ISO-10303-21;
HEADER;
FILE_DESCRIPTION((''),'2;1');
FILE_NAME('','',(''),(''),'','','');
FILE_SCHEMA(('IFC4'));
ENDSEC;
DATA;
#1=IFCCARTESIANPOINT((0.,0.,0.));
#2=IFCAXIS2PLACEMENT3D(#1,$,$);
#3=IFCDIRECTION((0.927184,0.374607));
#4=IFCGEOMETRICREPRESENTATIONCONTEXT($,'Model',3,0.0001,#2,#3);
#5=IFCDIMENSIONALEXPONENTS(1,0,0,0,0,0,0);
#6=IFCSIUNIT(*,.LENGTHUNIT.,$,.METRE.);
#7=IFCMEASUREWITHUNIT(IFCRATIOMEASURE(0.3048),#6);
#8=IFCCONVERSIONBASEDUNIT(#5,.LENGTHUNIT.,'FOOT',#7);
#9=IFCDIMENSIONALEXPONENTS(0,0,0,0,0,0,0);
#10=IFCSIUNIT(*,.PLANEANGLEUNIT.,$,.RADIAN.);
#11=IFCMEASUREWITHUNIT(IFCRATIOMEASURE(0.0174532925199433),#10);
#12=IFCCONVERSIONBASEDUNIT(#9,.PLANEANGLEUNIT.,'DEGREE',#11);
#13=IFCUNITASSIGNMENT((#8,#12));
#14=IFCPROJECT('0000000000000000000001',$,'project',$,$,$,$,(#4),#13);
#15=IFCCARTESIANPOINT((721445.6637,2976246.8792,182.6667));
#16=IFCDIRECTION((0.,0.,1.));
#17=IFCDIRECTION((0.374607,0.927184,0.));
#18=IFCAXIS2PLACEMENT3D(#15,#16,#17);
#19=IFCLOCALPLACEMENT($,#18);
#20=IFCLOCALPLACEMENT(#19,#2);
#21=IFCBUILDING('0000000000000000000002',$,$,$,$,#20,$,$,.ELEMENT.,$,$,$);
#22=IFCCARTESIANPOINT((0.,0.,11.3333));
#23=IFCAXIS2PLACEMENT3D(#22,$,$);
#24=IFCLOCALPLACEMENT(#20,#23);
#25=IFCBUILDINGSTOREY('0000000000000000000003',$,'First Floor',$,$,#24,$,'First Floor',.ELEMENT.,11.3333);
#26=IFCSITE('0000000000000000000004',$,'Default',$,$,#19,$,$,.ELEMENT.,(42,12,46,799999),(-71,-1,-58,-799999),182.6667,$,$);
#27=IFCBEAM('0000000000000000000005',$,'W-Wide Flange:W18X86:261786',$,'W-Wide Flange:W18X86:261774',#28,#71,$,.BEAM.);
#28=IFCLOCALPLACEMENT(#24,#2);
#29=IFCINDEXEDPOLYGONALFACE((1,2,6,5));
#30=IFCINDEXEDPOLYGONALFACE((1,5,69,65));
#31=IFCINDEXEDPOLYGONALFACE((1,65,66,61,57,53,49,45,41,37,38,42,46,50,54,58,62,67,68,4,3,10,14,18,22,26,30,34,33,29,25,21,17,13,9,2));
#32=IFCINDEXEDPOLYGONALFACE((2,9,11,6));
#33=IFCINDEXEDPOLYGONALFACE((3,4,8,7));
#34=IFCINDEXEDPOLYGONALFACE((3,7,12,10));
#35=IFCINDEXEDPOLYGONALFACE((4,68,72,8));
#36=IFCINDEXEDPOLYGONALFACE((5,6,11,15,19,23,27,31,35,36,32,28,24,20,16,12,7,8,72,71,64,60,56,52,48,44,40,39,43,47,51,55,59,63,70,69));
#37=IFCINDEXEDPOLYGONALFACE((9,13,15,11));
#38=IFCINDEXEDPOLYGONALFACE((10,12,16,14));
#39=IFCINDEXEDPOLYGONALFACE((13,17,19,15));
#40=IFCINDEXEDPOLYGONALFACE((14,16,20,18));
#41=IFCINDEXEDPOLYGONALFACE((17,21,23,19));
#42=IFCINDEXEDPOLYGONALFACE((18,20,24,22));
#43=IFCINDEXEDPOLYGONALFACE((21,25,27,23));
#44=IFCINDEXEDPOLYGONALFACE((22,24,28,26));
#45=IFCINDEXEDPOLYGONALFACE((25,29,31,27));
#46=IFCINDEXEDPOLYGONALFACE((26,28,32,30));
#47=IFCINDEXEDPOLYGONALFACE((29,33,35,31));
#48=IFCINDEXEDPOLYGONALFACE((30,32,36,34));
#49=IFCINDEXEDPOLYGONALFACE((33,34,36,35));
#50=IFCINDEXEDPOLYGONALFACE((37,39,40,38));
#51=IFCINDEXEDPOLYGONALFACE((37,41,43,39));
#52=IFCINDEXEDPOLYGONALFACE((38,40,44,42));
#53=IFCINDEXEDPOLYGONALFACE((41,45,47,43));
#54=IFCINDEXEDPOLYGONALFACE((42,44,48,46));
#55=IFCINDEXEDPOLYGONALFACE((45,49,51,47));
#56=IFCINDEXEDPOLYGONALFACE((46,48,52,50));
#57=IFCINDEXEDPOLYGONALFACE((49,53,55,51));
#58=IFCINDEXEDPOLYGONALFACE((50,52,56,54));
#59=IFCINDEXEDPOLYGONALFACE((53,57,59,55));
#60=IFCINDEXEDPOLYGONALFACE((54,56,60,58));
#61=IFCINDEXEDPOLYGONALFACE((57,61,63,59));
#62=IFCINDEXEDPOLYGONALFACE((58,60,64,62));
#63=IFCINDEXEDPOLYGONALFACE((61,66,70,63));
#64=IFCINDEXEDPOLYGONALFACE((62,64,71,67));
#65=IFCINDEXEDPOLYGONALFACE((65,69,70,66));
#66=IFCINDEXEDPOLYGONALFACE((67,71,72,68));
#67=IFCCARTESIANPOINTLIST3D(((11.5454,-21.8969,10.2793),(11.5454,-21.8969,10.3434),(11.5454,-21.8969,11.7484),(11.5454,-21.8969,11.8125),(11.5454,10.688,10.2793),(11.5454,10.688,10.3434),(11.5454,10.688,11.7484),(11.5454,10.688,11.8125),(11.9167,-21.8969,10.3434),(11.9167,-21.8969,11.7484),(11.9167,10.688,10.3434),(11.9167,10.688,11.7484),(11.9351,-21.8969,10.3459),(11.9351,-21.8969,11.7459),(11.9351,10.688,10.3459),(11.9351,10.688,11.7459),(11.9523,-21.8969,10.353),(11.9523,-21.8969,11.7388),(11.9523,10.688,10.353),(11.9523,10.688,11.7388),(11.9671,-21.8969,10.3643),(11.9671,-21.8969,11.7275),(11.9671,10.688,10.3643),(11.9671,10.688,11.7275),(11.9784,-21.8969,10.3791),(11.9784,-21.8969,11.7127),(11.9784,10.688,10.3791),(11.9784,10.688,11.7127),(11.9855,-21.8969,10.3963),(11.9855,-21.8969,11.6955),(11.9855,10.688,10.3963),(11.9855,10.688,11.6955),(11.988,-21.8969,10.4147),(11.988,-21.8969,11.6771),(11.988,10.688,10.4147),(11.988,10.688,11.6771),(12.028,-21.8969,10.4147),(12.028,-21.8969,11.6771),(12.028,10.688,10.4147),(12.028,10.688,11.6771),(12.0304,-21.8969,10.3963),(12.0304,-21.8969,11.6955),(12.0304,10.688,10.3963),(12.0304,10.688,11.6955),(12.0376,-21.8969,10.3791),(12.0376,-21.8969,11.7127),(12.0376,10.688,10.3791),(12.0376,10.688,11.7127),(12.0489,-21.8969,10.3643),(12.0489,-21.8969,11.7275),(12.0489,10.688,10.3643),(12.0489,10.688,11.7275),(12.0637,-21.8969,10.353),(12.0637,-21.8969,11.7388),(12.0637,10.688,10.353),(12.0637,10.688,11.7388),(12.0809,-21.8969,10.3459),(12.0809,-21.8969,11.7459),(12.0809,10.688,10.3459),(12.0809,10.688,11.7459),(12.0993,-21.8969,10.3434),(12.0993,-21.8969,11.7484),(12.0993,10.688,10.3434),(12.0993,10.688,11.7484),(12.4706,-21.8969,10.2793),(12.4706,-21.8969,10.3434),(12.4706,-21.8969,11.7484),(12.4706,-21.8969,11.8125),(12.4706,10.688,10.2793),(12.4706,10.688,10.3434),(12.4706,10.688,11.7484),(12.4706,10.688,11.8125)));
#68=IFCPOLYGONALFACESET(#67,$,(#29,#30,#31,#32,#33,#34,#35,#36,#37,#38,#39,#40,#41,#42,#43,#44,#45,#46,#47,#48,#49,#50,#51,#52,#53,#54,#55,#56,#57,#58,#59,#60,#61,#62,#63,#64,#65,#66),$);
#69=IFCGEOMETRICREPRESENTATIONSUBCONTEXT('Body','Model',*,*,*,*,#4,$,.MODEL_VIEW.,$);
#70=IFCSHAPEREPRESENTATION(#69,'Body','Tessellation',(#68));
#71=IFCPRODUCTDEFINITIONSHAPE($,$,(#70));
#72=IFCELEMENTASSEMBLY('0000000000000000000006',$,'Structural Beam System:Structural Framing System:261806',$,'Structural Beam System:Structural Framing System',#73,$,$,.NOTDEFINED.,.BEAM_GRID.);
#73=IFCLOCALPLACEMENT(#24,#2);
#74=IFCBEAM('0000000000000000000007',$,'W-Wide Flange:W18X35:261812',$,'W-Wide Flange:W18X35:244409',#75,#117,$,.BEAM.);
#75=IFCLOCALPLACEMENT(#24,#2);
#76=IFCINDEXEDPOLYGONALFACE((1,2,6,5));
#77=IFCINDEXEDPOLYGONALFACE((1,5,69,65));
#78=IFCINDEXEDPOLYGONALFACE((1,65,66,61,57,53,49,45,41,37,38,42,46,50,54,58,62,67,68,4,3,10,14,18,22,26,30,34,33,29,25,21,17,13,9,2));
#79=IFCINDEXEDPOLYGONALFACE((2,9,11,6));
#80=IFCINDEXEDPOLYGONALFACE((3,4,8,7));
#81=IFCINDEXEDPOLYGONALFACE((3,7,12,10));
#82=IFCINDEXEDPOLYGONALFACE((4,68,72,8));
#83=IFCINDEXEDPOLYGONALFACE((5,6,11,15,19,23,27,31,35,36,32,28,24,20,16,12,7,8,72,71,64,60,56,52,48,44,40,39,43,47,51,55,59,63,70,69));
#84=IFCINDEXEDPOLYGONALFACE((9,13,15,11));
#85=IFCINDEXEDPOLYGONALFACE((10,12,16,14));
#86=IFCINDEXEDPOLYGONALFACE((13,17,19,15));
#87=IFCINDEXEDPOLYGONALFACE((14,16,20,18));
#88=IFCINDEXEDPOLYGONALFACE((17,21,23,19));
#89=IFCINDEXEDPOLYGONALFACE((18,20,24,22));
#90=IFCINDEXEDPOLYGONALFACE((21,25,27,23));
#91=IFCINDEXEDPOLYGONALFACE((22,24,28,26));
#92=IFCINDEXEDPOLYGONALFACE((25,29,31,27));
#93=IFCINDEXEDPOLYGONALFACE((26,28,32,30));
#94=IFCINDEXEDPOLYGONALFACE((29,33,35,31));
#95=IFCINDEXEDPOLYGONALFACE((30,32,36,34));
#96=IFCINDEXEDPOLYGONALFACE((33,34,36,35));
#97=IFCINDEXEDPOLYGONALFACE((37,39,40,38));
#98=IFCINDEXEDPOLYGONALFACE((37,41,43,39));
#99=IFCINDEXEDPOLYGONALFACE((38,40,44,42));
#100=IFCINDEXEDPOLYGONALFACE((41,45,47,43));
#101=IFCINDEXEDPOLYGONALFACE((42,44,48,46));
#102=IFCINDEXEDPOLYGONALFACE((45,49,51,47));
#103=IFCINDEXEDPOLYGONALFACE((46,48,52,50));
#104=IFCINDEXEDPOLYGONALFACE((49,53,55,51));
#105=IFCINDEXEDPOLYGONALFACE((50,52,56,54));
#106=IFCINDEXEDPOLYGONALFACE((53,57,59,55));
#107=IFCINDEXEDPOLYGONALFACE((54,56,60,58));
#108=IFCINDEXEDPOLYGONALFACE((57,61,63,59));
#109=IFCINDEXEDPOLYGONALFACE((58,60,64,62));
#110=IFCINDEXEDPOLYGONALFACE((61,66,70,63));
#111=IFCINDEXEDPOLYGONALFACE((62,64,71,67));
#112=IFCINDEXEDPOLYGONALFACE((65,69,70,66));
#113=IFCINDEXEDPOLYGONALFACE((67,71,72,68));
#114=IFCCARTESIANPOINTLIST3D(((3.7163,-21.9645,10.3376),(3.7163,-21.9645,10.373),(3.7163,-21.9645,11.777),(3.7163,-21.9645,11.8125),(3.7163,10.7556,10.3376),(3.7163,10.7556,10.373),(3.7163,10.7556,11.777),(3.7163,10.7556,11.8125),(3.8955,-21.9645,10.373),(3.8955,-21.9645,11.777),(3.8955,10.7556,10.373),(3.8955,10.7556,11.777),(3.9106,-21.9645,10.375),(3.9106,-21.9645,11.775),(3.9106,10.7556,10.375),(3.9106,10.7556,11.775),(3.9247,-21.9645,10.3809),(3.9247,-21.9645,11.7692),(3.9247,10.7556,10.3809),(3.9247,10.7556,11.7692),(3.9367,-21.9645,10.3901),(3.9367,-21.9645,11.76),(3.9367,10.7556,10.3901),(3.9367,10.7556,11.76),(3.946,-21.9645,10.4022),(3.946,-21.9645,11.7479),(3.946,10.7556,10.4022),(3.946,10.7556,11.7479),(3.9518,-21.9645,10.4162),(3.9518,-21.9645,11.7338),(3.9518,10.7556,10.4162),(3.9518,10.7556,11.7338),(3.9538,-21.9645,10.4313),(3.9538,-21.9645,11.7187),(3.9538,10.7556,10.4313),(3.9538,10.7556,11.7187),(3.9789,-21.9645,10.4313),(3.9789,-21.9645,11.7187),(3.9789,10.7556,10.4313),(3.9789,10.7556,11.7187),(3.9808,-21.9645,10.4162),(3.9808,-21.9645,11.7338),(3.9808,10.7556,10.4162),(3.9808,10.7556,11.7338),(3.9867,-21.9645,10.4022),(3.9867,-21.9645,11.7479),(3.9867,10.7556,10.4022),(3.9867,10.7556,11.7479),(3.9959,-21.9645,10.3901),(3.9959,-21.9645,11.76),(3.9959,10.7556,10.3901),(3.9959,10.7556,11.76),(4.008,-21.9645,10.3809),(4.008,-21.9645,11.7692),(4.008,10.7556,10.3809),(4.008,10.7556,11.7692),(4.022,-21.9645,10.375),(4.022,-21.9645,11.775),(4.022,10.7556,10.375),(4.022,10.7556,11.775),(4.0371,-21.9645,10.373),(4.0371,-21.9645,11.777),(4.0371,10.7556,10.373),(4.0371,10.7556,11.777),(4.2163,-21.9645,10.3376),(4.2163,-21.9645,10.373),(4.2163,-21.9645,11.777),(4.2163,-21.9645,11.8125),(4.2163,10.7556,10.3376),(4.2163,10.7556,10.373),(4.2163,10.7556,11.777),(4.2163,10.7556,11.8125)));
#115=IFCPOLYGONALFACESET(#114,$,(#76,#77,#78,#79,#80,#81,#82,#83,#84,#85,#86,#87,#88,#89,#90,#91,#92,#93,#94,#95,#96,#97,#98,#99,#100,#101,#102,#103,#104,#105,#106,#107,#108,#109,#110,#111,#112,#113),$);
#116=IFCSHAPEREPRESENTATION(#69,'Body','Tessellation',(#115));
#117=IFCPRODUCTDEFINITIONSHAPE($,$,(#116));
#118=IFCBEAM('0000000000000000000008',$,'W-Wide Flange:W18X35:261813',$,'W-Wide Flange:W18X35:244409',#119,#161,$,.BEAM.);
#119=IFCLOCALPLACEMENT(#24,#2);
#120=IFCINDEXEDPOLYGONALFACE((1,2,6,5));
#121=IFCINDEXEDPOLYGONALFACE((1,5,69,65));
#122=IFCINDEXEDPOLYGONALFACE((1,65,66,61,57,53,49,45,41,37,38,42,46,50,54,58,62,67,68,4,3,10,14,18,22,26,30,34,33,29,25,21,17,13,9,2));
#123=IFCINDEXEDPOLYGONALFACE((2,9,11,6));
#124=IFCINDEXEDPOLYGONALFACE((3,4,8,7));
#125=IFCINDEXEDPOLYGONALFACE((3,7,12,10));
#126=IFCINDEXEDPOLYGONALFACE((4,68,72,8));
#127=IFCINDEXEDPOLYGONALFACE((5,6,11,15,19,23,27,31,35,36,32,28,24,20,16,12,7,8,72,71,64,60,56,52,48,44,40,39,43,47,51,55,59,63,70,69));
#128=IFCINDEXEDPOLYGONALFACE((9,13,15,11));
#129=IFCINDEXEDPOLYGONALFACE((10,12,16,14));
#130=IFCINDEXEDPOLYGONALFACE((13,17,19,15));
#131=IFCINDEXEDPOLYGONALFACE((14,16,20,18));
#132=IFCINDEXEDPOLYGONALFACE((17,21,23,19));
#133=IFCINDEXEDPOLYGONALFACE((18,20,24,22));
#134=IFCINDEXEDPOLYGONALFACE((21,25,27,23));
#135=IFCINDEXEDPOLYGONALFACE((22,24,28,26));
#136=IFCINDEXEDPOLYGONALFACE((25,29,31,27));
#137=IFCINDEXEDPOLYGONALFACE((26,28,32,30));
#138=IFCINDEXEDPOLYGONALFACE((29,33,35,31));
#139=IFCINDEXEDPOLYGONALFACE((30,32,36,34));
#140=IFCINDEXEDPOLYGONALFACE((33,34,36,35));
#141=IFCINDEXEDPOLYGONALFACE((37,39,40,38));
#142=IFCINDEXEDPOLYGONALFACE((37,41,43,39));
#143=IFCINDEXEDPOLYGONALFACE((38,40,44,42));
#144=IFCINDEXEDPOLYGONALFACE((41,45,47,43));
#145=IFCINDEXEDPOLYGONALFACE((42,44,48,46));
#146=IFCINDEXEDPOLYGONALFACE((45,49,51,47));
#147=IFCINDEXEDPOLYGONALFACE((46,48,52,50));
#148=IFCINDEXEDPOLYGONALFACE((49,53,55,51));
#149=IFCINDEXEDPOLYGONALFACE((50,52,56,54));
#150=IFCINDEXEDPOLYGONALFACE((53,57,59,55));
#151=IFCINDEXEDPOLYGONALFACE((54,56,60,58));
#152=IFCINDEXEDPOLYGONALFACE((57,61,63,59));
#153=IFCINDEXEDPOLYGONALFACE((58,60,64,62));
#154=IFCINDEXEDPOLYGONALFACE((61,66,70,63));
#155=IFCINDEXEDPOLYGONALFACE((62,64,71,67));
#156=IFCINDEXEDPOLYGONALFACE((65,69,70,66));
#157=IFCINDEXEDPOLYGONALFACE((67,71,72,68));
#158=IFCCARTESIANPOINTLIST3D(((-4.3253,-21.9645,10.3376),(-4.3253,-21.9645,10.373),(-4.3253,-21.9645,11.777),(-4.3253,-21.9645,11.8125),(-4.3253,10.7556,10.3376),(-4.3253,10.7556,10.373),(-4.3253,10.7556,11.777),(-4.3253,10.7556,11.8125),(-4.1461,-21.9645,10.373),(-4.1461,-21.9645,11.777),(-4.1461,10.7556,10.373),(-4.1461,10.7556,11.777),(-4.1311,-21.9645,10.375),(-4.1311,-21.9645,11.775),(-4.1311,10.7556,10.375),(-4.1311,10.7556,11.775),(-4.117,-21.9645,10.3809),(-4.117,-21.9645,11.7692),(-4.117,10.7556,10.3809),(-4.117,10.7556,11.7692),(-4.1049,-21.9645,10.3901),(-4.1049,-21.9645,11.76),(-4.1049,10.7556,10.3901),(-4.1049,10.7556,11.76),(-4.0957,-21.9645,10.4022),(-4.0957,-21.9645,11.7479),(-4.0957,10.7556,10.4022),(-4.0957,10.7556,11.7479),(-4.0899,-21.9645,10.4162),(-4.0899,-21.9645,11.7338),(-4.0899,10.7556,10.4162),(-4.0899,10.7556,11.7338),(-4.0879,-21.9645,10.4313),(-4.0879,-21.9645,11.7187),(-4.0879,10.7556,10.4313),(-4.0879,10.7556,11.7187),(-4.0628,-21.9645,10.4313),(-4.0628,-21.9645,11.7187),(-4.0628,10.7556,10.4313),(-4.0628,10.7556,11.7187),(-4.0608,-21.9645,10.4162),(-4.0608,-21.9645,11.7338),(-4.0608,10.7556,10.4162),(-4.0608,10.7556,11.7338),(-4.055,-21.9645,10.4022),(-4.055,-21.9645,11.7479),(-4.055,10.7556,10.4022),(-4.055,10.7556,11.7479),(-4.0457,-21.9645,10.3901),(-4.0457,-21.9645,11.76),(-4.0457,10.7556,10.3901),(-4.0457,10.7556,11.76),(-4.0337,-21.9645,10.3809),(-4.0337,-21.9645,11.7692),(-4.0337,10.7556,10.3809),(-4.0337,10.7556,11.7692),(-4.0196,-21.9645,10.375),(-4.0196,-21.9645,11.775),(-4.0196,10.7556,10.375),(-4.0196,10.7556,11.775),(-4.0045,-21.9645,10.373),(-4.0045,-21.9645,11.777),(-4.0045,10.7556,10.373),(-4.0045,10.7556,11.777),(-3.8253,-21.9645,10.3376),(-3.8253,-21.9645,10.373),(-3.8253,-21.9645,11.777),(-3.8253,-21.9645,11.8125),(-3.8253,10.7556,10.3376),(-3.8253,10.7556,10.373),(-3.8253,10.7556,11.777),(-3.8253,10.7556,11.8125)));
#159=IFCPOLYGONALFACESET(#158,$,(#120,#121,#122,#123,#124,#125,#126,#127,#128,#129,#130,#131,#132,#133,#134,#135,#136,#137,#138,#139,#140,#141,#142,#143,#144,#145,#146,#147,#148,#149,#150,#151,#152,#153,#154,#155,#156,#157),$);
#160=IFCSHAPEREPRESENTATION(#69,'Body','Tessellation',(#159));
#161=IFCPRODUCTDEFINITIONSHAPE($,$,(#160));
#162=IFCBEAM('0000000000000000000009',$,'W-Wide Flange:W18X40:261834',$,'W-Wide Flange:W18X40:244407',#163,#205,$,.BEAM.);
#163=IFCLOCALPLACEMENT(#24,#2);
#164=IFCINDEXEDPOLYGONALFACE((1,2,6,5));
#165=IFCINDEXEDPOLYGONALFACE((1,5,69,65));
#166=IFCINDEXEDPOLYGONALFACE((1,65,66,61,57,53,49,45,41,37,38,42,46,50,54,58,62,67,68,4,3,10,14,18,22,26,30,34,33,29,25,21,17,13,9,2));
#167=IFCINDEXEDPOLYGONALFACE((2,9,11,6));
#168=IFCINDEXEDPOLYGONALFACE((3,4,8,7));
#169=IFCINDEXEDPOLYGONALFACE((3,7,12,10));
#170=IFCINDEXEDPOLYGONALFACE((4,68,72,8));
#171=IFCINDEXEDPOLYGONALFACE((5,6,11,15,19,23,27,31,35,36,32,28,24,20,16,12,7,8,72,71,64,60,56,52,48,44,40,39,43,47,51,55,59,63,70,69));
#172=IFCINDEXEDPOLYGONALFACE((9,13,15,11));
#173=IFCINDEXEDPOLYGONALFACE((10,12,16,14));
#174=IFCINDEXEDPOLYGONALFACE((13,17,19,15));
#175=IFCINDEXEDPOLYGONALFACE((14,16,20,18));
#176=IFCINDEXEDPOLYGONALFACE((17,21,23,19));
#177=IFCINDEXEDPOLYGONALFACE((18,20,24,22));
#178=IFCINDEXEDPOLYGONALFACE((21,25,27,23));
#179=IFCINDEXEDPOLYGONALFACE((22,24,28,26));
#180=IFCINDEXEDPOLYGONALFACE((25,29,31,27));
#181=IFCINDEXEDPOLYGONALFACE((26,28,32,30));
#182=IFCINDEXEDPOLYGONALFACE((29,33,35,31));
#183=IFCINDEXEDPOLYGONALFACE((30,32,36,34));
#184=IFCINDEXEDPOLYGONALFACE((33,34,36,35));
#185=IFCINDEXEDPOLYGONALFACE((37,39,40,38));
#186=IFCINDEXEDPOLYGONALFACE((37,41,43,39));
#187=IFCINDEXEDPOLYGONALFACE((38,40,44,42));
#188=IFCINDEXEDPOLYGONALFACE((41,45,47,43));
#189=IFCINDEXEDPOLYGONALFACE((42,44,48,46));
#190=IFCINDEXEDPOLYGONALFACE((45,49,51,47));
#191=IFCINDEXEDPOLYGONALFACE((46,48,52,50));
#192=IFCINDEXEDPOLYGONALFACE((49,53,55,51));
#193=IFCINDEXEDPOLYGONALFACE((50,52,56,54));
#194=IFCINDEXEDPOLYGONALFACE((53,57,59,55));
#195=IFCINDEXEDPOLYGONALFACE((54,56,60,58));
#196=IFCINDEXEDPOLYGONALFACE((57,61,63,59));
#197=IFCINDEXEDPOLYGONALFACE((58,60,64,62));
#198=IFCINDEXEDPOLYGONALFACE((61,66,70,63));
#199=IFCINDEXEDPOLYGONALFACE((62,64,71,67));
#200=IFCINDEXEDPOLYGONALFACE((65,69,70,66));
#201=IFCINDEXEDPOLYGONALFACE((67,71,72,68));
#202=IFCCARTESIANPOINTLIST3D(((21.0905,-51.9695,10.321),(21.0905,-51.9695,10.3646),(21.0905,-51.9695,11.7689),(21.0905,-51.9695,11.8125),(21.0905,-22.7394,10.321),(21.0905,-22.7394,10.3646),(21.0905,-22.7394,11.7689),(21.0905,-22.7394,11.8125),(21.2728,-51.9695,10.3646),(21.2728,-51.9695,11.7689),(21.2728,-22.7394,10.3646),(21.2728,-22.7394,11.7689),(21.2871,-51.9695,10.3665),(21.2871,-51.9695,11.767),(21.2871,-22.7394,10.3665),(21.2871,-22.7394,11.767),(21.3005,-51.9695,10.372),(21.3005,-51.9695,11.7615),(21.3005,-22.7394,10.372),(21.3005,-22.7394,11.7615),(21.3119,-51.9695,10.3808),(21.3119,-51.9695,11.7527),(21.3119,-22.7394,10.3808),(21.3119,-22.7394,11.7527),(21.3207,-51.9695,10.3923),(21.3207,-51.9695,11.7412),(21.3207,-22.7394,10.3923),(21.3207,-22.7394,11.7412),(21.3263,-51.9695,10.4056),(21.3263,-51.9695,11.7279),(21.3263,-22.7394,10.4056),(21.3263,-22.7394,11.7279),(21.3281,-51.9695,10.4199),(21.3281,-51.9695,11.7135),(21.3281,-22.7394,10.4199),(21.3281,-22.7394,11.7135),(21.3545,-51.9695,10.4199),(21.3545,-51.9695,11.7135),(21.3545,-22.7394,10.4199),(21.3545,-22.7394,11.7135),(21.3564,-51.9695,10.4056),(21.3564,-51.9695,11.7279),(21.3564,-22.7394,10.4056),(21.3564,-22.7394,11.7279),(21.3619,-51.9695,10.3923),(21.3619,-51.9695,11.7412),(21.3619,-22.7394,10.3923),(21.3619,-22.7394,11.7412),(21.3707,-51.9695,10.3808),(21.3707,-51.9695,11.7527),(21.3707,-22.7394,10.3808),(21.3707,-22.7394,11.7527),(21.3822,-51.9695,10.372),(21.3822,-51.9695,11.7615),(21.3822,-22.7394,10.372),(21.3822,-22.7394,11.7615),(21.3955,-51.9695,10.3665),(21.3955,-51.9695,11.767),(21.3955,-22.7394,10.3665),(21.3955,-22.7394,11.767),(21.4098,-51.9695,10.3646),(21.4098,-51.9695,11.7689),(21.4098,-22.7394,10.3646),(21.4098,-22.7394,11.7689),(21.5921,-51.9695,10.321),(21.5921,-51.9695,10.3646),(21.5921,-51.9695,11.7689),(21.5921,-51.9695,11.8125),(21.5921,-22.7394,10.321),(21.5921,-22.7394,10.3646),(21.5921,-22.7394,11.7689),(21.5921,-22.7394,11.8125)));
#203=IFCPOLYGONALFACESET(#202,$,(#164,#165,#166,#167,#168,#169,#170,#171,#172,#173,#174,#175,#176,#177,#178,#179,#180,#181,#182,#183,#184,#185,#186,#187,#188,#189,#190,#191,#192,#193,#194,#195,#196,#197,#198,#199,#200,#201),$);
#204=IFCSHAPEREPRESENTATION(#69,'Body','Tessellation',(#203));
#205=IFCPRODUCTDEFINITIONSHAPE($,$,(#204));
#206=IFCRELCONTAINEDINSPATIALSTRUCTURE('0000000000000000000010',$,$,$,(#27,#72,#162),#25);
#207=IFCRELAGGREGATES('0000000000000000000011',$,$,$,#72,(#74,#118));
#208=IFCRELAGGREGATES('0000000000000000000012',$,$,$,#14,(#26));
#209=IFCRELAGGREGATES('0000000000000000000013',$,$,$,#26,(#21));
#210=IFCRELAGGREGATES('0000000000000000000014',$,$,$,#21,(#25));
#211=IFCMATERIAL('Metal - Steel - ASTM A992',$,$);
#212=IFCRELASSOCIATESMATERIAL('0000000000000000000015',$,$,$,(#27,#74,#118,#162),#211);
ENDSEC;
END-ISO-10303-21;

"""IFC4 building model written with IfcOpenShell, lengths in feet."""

from ifc_helpers import new_model, entity, si_unit, converted_unit, direction, frame, frame_2d, origin, place, context, subcontext, project, spatial, i_section, extrude, material, element, aggregate, save


model = new_model("IFC4")

# Units and contexts
model_context = context("Model", 3, precision=0.0001, world=origin(), true_north=direction((0.927184, 0.374607)))
body_context = subcontext(model_context, "Body", "Model", "MODEL_VIEW")
ifc_project = project(units=[converted_unit("LENGTHUNIT", "FOOT", entity("IfcRatioMeasure", 0.3048), si_unit("LENGTHUNIT", "METRE"), dimensions=[1, 0, 0, 0, 0, 0, 0]), converted_unit("PLANEANGLEUNIT", "DEGREE", entity("IfcRatioMeasure", 0.0174532925199433), si_unit("PLANEANGLEUNIT", "RADIAN"), dimensions=[0, 0, 0, 0, 0, 0, 0])], contexts=[model_context])

# Site, building, storey
site_placement = place(None, frame((721445.6637, 2976246.8792, 182.6667), z_axis=(0.0, 0.0, 1.0), x_axis=(0.374607, 0.927184, 0.0)))
site = spatial("IfcSite", under=ifc_project, at=site_placement, Name="Default", CompositionType="ELEMENT", RefLatitude=(42, 12, 46, 799999), RefLongitude=(-71, -1, -58, -799999), RefElevation=182.6667)
building_placement = place(site_placement, origin())
building = spatial("IfcBuilding", under=site, at=building_placement, CompositionType="ELEMENT")
storey_placement = place(building_placement, frame((0.0, 0.0, 11.3333)))
storey = spatial("IfcBuildingStorey", under=building, at=storey_placement, Name="First Floor", LongName="First Floor", CompositionType="ELEMENT", Elevation=11.3333)

# Beam
ifc_material_1 = material(Name="Metal - Steel - ASTM A992")
beam_1_placement = place(storey_placement, frame((12.008, -22.3544, 11.8125), z_axis=(0.0, 0.0, 1.0), x_axis=(0.0, 1.0, 0.0)))
element("IfcBeam", 1, at=beam_1_placement, inside=storey, material=ifc_material_1, Name="W-Wide Flange:W18X86:261786", ObjectType="W-Wide Flange:W18X86:261774", PredefinedType="BEAM", context=body_context, shape_type="SweptSolid", body=[
    extrude(i_section(OverallWidth=0.9251, OverallDepth=1.5332, WebThickness=0.04, FlangeThickness=0.0641, FilletRadius=0.0713, at=frame_2d((0.0, 0.0), x_axis=(0.0, 1.0))), frame((0.4575, 0.0, -0.7666), z_axis=(1.0, 0.0, 0.0), x_axis=(0.0, 0.0, -1.0)), (0.0, 0.0, 1.0), 32.585),
])

# Element assembly, beams
assembly_1_placement = place(storey_placement, origin())
assembly_1 = element("IfcElementAssembly", 2, at=assembly_1_placement, inside=storey, Name="Structural Beam System:Structural Framing System:261806", ObjectType="Structural Beam System:Structural Framing System", AssemblyPlace="NOTDEFINED", PredefinedType="BEAM_GRID")
beam_2_placement = place(assembly_1_placement, frame((3.9663, 11.1456, 11.8125), z_axis=(0.0, 0.0, 1.0), x_axis=(0.0, -1.0, 0.0)))
beam_2 = element("IfcBeam", 3, at=beam_2_placement, material=ifc_material_1, Name="W-Wide Flange:W18X35:261812", ObjectType="W-Wide Flange:W18X35:244409", PredefinedType="BEAM", context=body_context, shape_type="SweptSolid", body=[
    extrude(i_section(OverallWidth=0.5, OverallDepth=1.4749, WebThickness=0.0251, FlangeThickness=0.0355, FilletRadius=0.0583, at=frame_2d((0.0, 0.0), x_axis=(0.0, 1.0))), frame((0.39, 0.0, -0.7375), z_axis=(1.0, 0.0, 0.0), x_axis=(0.0, 0.0, -1.0)), (0.0, 0.0, 1.0), 32.7201),
])
beam_3_placement = place(assembly_1_placement, frame((-4.0753, 11.1456, 11.8125), z_axis=(0.0, 0.0, 1.0), x_axis=(0.0, -1.0, 0.0)))
beam_3 = element("IfcBeam", 4, at=beam_3_placement, material=ifc_material_1, Name="W-Wide Flange:W18X35:261813", ObjectType="W-Wide Flange:W18X35:244409", PredefinedType="BEAM", context=body_context, shape_type="SweptSolid", body=[
    extrude(i_section(OverallWidth=0.5, OverallDepth=1.4749, WebThickness=0.0251, FlangeThickness=0.0355, FilletRadius=0.0583, at=frame_2d((0.0, 0.0), x_axis=(0.0, 1.0))), frame((0.39, 0.0, -0.7375), z_axis=(1.0, 0.0, 0.0), x_axis=(0.0, 0.0, -1.0)), (0.0, 0.0, 1.0), 32.7201),
])
aggregate(assembly_1, [beam_2, beam_3])

# Beam
beam_4_placement = place(storey_placement, frame((21.3413, -22.3544, 11.8125), z_axis=(0.0, 0.0, 1.0), x_axis=(0.0, -1.0, 0.0)))
element("IfcBeam", 5, at=beam_4_placement, inside=storey, material=ifc_material_1, Name="W-Wide Flange:W18X40:261834", ObjectType="W-Wide Flange:W18X40:244407", PredefinedType="BEAM", context=body_context, shape_type="SweptSolid", body=[
    extrude(i_section(OverallWidth=0.5016, OverallDepth=1.4915, WebThickness=0.0264, FlangeThickness=0.0436, FilletRadius=0.0553, at=frame_2d((0.0, 0.0), x_axis=(0.0, 1.0))), frame((0.3849, 0.0, -0.7458), z_axis=(1.0, 0.0, 0.0), x_axis=(0.0, 0.0, -1.0)), (0.0, 0.0, 1.0), 29.2301),
])

save(model, "model.ifc")
